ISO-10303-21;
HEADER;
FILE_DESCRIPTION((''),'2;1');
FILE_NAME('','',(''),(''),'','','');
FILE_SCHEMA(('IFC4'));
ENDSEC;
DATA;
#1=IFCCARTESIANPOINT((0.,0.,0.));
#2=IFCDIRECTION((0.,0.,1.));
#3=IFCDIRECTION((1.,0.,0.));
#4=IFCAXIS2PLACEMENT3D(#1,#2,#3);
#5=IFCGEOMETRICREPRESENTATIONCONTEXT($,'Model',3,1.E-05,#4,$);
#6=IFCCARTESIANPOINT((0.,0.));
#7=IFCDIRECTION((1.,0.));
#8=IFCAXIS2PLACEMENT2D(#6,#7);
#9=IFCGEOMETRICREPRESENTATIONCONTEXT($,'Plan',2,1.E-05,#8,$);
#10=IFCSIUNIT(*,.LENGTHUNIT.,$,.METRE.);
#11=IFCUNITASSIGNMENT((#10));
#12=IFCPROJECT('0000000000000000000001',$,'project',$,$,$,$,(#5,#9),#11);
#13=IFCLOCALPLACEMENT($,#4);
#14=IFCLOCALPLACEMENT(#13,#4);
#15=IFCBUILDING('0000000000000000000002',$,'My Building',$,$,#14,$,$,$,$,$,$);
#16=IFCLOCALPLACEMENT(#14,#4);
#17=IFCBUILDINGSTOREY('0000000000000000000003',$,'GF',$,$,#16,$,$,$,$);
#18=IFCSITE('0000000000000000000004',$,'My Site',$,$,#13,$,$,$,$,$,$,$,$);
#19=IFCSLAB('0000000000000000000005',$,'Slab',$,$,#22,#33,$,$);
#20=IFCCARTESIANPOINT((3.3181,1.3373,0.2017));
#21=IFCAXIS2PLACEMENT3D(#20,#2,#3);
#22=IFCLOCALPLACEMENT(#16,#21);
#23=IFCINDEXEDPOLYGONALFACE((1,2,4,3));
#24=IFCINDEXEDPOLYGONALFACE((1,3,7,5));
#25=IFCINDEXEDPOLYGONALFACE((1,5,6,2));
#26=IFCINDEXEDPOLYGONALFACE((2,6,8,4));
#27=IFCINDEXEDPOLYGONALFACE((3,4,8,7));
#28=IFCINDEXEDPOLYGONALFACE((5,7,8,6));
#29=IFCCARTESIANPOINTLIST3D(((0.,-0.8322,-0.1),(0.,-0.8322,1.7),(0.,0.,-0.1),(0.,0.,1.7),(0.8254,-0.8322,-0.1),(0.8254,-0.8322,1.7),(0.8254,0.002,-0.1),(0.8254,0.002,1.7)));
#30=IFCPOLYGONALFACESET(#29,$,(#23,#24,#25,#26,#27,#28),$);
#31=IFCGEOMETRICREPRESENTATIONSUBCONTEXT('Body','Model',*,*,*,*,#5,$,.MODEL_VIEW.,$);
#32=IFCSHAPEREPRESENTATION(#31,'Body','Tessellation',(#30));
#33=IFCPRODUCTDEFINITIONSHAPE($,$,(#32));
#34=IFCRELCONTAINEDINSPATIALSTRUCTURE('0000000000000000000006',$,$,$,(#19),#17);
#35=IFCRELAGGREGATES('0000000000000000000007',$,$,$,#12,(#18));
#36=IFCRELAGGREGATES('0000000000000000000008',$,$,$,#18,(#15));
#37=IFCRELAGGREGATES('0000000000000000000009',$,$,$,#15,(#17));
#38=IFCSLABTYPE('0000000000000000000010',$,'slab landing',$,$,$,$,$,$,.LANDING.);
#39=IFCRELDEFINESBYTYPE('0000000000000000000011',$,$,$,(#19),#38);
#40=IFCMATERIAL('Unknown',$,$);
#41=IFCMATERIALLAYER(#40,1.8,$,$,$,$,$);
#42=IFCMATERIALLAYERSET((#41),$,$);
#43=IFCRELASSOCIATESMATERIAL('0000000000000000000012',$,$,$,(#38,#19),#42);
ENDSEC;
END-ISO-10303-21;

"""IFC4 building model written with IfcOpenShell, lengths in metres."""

from ifc_helpers import new_model, si_unit, frame, origin_with_axes, origin_2d_with_axis, place, context, subcontext, project, spatial, indexed_curve, outline, extrude, material, layer, layer_set, layer_usage, type_object, element, save


model = new_model("IFC4")

# Units and contexts
model_context = context("Model", 3, precision=1e-05, world=origin_with_axes())
plan_context = context("Plan", 2, precision=1e-05, world=origin_2d_with_axis())
body_context_1 = subcontext(model_context, "Body", "Model", "MODEL_VIEW")
ifc_project = project(units=[si_unit("LENGTHUNIT", "METRE")], contexts=[model_context, plan_context])

# Site, building, storey
site_placement = place(None, origin_with_axes())
site = spatial("IfcSite", under=ifc_project, at=site_placement, Name="My Site")
building_placement = place(site_placement, origin_with_axes())
building = spatial("IfcBuilding", under=site, at=building_placement, Name="My Building")
storey_placement = place(building_placement, origin_with_axes())
storey = spatial("IfcBuildingStorey", under=building, at=storey_placement, Name="GF")

# Shared definitions
ifc_material = material(Name="Unknown")

# Slab
ifc_layer_1 = layer(ifc_material, 1.8)
ifc_layer_set_1 = layer_set([ifc_layer_1])
ifc_layer_usage_1 = layer_usage(ifc_layer_set_1, "AXIS3", "POSITIVE", -0.1)
slab_type_1 = type_object("IfcSlabType", Name="slab landing", PredefinedType="LANDING", material=ifc_layer_set_1)
slab_1_placement = place(storey_placement, frame((3.3181, 1.3373, 0.2017), z_axis=(0.0, 0.0, 1.0), x_axis=(1.0, 0.0, 0.0)))
element("IfcSlab", 1, at=slab_1_placement, inside=storey, type_object=slab_type_1, material=ifc_layer_usage_1, Name="Slab", context=body_context_1, shape_type="SweptSolid", body=[
    extrude(outline(indexed_curve([(0.0, 0.0), (0.0, -0.8322), (0.8254, -0.8322), (0.8254, 0.002), (0.0, 0.0)])), frame((0.0, 0.0, -0.1), z_axis=(0.0, 0.0, 1.0), x_axis=(1.0, 0.0, 0.0)), (0.0, 0.0, 1.0), 1.8),
])

save(model, "model.ifc")
